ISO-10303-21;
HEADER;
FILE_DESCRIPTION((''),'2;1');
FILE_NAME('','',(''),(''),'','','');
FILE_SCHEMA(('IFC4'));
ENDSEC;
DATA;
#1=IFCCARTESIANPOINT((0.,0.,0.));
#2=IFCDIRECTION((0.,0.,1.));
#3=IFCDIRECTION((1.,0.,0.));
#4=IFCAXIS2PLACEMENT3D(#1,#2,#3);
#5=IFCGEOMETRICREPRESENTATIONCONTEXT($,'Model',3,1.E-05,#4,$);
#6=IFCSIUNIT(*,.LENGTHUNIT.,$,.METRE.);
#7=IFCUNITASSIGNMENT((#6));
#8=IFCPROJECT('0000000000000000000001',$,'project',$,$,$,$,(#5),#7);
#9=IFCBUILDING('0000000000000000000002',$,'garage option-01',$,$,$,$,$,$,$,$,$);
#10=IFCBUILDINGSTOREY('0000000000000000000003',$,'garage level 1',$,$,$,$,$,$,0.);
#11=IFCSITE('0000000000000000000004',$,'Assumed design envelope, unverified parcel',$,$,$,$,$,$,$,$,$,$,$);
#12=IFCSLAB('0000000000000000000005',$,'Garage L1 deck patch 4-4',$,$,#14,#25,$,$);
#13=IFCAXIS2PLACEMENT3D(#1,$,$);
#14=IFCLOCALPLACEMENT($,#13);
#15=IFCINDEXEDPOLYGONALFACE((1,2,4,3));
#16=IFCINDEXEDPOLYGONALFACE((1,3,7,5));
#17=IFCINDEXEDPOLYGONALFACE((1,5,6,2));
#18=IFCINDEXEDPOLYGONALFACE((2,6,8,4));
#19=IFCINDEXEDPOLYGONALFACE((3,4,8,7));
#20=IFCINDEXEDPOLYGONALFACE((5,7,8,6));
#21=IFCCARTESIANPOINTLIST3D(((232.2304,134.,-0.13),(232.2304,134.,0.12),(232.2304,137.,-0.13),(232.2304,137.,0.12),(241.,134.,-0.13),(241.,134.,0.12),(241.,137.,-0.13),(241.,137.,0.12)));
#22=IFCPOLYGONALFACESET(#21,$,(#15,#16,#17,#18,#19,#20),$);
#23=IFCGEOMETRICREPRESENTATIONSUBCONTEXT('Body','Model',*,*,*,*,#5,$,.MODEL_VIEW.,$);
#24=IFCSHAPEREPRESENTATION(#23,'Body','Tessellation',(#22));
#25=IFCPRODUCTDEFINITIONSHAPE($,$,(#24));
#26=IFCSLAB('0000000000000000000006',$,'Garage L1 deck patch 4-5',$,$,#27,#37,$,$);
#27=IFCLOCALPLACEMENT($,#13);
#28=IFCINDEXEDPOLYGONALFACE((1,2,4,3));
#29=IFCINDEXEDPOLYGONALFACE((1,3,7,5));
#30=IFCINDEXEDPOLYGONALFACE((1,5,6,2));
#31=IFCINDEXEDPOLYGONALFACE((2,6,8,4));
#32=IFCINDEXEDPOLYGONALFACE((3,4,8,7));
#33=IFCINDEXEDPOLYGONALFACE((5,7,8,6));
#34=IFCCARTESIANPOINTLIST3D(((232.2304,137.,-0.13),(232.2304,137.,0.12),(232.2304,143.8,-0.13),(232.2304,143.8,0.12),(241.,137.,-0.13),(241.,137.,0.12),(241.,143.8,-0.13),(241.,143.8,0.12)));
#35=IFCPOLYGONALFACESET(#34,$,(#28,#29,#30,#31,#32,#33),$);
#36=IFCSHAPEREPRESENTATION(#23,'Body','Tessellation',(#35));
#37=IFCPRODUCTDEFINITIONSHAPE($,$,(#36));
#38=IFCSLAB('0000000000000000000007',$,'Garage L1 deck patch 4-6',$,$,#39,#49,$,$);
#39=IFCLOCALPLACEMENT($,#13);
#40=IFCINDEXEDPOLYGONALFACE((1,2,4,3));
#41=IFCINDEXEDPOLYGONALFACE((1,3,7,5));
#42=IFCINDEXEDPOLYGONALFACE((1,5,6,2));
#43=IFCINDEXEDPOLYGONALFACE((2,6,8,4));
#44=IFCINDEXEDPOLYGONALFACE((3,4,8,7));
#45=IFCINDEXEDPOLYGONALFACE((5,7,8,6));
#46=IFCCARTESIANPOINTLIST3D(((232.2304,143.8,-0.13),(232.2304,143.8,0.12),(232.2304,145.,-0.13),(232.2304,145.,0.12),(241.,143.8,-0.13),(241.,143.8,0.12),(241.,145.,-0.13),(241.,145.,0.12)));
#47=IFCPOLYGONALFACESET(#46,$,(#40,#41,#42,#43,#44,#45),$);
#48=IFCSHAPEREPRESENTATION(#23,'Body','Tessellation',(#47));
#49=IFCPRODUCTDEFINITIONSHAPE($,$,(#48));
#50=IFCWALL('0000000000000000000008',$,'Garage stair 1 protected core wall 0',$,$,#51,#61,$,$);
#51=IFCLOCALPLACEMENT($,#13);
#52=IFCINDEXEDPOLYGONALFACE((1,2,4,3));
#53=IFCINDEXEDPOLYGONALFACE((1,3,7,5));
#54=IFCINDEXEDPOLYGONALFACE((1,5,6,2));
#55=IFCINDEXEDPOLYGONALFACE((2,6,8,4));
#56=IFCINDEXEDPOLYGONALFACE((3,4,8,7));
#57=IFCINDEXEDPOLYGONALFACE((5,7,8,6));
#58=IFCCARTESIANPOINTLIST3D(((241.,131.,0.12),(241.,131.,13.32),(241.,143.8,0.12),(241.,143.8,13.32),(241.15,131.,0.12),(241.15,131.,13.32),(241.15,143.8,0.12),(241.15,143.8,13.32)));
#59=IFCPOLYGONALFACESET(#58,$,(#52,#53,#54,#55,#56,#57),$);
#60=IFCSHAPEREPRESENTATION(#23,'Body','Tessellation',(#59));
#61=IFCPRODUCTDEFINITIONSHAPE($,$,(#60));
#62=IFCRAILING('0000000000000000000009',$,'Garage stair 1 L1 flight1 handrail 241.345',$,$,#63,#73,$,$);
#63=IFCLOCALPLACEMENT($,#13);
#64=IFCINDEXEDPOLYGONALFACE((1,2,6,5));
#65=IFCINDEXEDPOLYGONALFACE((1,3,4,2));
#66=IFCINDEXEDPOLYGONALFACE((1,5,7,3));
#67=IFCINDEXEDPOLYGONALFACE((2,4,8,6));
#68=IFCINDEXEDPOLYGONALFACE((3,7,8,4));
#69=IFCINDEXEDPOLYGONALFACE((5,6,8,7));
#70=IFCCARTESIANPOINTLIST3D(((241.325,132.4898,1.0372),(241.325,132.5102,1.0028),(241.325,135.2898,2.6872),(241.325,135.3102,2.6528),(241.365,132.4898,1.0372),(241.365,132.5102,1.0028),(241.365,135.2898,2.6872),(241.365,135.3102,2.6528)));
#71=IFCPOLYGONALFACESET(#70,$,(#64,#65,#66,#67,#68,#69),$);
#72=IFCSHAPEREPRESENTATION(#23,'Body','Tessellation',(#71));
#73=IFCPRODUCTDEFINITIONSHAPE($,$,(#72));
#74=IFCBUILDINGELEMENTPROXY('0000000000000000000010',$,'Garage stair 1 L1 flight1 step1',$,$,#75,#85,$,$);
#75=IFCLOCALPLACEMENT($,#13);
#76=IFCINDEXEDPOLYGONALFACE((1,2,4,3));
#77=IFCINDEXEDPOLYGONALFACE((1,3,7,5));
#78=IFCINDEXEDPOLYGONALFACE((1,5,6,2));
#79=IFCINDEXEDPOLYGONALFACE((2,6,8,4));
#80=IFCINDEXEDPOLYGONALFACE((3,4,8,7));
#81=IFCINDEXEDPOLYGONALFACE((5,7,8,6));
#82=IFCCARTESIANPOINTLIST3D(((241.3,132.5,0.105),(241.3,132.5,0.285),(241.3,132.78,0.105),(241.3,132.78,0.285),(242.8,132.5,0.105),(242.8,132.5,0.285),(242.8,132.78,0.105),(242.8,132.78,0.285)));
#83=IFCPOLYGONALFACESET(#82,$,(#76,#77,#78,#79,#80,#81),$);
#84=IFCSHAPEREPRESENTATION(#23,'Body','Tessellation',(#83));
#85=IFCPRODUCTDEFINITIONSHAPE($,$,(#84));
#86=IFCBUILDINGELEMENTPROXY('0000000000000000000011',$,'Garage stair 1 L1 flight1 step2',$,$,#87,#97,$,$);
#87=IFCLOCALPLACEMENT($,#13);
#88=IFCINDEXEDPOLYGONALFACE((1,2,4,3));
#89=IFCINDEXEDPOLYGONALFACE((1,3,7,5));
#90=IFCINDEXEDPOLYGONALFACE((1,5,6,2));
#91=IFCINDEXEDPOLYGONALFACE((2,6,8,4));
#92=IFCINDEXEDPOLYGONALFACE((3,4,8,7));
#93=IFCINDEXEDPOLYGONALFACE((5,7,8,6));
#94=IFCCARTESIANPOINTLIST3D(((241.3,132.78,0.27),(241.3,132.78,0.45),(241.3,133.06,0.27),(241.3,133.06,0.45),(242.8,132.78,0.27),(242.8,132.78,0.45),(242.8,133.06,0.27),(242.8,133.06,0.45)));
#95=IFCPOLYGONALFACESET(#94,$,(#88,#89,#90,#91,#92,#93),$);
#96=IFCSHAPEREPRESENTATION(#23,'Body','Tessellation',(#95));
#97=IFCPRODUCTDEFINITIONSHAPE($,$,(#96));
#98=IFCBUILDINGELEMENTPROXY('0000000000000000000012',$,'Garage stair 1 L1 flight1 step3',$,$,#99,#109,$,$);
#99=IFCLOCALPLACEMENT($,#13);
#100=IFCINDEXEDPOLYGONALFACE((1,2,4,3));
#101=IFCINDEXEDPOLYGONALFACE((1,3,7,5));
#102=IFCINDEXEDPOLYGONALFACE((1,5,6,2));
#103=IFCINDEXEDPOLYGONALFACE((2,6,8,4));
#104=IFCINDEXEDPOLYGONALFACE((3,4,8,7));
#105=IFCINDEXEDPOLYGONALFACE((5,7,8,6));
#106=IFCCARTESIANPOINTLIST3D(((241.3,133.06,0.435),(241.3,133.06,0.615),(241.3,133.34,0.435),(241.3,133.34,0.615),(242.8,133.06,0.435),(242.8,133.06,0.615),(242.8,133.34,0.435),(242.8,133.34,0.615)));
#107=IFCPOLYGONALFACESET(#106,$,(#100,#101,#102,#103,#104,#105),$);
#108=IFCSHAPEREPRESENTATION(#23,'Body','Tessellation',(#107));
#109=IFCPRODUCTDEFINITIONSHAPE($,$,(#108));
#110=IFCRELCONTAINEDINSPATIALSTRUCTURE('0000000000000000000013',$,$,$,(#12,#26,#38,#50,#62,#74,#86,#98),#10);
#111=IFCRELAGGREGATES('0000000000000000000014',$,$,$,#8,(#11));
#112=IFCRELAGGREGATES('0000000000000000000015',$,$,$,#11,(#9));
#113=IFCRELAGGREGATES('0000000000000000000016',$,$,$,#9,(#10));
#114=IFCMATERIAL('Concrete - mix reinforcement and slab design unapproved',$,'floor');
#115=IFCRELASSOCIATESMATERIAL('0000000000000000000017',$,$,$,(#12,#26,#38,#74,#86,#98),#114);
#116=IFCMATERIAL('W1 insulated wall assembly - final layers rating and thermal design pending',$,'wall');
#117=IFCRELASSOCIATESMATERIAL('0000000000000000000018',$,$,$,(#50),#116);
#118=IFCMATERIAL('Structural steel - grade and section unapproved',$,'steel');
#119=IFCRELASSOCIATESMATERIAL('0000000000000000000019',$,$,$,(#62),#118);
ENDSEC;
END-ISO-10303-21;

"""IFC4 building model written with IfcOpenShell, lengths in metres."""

from ifc_helpers import new_model, si_unit, frame, origin_with_axes, place, context, subcontext, project, spatial, rectangle, extrude, material, element, save


model = new_model("IFC4")

# Units and contexts
model_context = context("Model", 3, precision=1e-05, world=origin_with_axes())
body_context = subcontext(model_context, "Body", "Model", "MODEL_VIEW")
ifc_project = project(units=[si_unit("LENGTHUNIT", "METRE")], contexts=[model_context])

# Site, building, storey
site = spatial("IfcSite", under=ifc_project, Name="Assumed design envelope, unverified parcel")
building = spatial("IfcBuilding", under=site, Name="garage option-01")
storey = spatial("IfcBuildingStorey", under=building, Name="garage level 1", Elevation=0.0)

# Slabs
ifc_material_1 = material(Name="Concrete - mix reinforcement and slab design unapproved", Category="floor")
for number, where, z_axis, x_axis, name in (
    (1, (236.6152, 135.5, -0.13), (0.0, 0.0, 1.0), (1.0, 0.0, 0.0), "Garage L1 deck patch 4-4"),
):
    element("IfcSlab", number, at=place(None, frame(where, z_axis=z_axis, x_axis=x_axis)), inside=storey, material=ifc_material_1, Name=name, context=body_context, shape_type="SweptSolid", body=[
        extrude(rectangle(XDim=8.7696, YDim=3.0), origin_with_axes(), (0.0, 0.0, 1.0), 0.25),
    ])
slab_1_placement = place(None, frame((236.6152, 140.4, -0.13), z_axis=(0.0, 0.0, 1.0), x_axis=(1.0, 0.0, 0.0)))
element("IfcSlab", 2, at=slab_1_placement, inside=storey, material=ifc_material_1, Name="Garage L1 deck patch 4-5", context=body_context, shape_type="SweptSolid", body=[
    extrude(rectangle(XDim=8.7696, YDim=6.8), origin_with_axes(), (0.0, 0.0, 1.0), 0.25),
])
slab_2_placement = place(None, frame((236.6152, 144.4, -0.13), z_axis=(0.0, 0.0, 1.0), x_axis=(1.0, 0.0, 0.0)))
element("IfcSlab", 3, at=slab_2_placement, inside=storey, material=ifc_material_1, Name="Garage L1 deck patch 4-6", context=body_context, shape_type="SweptSolid", body=[
    extrude(rectangle(XDim=8.7696, YDim=1.2), origin_with_axes(), (0.0, 0.0, 1.0), 0.25),
])

# Wall
ifc_material_2 = material(Name="W1 insulated wall assembly - final layers rating and thermal design pending", Category="wall")
wall_placement = place(None, frame((241.075, 137.4, 0.12), z_axis=(0.0, 0.0, 1.0), x_axis=(1.0, 0.0, 0.0)))
element("IfcWall", 4, at=wall_placement, inside=storey, material=ifc_material_2, Name="Garage stair 1 protected core wall 0", context=body_context, shape_type="SweptSolid", body=[
    extrude(rectangle(XDim=0.15, YDim=12.8), origin_with_axes(), (0.0, 0.0, 1.0), 13.2),
])

# Railing
ifc_material_3 = material(Name="Structural steel - grade and section unapproved", Category="steel")
railing_placement = place(None, frame((241.345, 132.5, 1.02), z_axis=(0.0, 0.861539, 0.507692), x_axis=(-1.0, 0.0, 0.0)))
element("IfcRailing", 5, at=railing_placement, inside=storey, material=ifc_material_3, Name="Garage stair 1 L1 flight1 handrail 241.345", context=body_context, shape_type="SweptSolid", body=[
    extrude(rectangle(XDim=0.04, YDim=0.04), origin_with_axes(), (0.0, 0.0, 1.0), 3.25),
])

# Building element proxies
for number, where, z_axis, x_axis, name in (
    (6, (242.05, 132.64, 0.105), (0.0, 0.0, 1.0), (1.0, 0.0, 0.0), "Garage stair 1 L1 flight1 step1"),
    (7, (242.05, 132.92, 0.27), (0.0, 0.0, 1.0), (1.0, 0.0, 0.0), "Garage stair 1 L1 flight1 step2"),
    (8, (242.05, 133.2, 0.435), (0.0, 0.0, 1.0), (1.0, 0.0, 0.0), "Garage stair 1 L1 flight1 step3"),
):
    element("IfcBuildingElementProxy", number, at=place(None, frame(where, z_axis=z_axis, x_axis=x_axis)), inside=storey, material=ifc_material_1, Name=name, context=body_context, shape_type="SweptSolid", body=[
        extrude(rectangle(XDim=1.5, YDim=0.28), origin_with_axes(), (0.0, 0.0, 1.0), 0.18),
    ])

save(model, "model.ifc")
